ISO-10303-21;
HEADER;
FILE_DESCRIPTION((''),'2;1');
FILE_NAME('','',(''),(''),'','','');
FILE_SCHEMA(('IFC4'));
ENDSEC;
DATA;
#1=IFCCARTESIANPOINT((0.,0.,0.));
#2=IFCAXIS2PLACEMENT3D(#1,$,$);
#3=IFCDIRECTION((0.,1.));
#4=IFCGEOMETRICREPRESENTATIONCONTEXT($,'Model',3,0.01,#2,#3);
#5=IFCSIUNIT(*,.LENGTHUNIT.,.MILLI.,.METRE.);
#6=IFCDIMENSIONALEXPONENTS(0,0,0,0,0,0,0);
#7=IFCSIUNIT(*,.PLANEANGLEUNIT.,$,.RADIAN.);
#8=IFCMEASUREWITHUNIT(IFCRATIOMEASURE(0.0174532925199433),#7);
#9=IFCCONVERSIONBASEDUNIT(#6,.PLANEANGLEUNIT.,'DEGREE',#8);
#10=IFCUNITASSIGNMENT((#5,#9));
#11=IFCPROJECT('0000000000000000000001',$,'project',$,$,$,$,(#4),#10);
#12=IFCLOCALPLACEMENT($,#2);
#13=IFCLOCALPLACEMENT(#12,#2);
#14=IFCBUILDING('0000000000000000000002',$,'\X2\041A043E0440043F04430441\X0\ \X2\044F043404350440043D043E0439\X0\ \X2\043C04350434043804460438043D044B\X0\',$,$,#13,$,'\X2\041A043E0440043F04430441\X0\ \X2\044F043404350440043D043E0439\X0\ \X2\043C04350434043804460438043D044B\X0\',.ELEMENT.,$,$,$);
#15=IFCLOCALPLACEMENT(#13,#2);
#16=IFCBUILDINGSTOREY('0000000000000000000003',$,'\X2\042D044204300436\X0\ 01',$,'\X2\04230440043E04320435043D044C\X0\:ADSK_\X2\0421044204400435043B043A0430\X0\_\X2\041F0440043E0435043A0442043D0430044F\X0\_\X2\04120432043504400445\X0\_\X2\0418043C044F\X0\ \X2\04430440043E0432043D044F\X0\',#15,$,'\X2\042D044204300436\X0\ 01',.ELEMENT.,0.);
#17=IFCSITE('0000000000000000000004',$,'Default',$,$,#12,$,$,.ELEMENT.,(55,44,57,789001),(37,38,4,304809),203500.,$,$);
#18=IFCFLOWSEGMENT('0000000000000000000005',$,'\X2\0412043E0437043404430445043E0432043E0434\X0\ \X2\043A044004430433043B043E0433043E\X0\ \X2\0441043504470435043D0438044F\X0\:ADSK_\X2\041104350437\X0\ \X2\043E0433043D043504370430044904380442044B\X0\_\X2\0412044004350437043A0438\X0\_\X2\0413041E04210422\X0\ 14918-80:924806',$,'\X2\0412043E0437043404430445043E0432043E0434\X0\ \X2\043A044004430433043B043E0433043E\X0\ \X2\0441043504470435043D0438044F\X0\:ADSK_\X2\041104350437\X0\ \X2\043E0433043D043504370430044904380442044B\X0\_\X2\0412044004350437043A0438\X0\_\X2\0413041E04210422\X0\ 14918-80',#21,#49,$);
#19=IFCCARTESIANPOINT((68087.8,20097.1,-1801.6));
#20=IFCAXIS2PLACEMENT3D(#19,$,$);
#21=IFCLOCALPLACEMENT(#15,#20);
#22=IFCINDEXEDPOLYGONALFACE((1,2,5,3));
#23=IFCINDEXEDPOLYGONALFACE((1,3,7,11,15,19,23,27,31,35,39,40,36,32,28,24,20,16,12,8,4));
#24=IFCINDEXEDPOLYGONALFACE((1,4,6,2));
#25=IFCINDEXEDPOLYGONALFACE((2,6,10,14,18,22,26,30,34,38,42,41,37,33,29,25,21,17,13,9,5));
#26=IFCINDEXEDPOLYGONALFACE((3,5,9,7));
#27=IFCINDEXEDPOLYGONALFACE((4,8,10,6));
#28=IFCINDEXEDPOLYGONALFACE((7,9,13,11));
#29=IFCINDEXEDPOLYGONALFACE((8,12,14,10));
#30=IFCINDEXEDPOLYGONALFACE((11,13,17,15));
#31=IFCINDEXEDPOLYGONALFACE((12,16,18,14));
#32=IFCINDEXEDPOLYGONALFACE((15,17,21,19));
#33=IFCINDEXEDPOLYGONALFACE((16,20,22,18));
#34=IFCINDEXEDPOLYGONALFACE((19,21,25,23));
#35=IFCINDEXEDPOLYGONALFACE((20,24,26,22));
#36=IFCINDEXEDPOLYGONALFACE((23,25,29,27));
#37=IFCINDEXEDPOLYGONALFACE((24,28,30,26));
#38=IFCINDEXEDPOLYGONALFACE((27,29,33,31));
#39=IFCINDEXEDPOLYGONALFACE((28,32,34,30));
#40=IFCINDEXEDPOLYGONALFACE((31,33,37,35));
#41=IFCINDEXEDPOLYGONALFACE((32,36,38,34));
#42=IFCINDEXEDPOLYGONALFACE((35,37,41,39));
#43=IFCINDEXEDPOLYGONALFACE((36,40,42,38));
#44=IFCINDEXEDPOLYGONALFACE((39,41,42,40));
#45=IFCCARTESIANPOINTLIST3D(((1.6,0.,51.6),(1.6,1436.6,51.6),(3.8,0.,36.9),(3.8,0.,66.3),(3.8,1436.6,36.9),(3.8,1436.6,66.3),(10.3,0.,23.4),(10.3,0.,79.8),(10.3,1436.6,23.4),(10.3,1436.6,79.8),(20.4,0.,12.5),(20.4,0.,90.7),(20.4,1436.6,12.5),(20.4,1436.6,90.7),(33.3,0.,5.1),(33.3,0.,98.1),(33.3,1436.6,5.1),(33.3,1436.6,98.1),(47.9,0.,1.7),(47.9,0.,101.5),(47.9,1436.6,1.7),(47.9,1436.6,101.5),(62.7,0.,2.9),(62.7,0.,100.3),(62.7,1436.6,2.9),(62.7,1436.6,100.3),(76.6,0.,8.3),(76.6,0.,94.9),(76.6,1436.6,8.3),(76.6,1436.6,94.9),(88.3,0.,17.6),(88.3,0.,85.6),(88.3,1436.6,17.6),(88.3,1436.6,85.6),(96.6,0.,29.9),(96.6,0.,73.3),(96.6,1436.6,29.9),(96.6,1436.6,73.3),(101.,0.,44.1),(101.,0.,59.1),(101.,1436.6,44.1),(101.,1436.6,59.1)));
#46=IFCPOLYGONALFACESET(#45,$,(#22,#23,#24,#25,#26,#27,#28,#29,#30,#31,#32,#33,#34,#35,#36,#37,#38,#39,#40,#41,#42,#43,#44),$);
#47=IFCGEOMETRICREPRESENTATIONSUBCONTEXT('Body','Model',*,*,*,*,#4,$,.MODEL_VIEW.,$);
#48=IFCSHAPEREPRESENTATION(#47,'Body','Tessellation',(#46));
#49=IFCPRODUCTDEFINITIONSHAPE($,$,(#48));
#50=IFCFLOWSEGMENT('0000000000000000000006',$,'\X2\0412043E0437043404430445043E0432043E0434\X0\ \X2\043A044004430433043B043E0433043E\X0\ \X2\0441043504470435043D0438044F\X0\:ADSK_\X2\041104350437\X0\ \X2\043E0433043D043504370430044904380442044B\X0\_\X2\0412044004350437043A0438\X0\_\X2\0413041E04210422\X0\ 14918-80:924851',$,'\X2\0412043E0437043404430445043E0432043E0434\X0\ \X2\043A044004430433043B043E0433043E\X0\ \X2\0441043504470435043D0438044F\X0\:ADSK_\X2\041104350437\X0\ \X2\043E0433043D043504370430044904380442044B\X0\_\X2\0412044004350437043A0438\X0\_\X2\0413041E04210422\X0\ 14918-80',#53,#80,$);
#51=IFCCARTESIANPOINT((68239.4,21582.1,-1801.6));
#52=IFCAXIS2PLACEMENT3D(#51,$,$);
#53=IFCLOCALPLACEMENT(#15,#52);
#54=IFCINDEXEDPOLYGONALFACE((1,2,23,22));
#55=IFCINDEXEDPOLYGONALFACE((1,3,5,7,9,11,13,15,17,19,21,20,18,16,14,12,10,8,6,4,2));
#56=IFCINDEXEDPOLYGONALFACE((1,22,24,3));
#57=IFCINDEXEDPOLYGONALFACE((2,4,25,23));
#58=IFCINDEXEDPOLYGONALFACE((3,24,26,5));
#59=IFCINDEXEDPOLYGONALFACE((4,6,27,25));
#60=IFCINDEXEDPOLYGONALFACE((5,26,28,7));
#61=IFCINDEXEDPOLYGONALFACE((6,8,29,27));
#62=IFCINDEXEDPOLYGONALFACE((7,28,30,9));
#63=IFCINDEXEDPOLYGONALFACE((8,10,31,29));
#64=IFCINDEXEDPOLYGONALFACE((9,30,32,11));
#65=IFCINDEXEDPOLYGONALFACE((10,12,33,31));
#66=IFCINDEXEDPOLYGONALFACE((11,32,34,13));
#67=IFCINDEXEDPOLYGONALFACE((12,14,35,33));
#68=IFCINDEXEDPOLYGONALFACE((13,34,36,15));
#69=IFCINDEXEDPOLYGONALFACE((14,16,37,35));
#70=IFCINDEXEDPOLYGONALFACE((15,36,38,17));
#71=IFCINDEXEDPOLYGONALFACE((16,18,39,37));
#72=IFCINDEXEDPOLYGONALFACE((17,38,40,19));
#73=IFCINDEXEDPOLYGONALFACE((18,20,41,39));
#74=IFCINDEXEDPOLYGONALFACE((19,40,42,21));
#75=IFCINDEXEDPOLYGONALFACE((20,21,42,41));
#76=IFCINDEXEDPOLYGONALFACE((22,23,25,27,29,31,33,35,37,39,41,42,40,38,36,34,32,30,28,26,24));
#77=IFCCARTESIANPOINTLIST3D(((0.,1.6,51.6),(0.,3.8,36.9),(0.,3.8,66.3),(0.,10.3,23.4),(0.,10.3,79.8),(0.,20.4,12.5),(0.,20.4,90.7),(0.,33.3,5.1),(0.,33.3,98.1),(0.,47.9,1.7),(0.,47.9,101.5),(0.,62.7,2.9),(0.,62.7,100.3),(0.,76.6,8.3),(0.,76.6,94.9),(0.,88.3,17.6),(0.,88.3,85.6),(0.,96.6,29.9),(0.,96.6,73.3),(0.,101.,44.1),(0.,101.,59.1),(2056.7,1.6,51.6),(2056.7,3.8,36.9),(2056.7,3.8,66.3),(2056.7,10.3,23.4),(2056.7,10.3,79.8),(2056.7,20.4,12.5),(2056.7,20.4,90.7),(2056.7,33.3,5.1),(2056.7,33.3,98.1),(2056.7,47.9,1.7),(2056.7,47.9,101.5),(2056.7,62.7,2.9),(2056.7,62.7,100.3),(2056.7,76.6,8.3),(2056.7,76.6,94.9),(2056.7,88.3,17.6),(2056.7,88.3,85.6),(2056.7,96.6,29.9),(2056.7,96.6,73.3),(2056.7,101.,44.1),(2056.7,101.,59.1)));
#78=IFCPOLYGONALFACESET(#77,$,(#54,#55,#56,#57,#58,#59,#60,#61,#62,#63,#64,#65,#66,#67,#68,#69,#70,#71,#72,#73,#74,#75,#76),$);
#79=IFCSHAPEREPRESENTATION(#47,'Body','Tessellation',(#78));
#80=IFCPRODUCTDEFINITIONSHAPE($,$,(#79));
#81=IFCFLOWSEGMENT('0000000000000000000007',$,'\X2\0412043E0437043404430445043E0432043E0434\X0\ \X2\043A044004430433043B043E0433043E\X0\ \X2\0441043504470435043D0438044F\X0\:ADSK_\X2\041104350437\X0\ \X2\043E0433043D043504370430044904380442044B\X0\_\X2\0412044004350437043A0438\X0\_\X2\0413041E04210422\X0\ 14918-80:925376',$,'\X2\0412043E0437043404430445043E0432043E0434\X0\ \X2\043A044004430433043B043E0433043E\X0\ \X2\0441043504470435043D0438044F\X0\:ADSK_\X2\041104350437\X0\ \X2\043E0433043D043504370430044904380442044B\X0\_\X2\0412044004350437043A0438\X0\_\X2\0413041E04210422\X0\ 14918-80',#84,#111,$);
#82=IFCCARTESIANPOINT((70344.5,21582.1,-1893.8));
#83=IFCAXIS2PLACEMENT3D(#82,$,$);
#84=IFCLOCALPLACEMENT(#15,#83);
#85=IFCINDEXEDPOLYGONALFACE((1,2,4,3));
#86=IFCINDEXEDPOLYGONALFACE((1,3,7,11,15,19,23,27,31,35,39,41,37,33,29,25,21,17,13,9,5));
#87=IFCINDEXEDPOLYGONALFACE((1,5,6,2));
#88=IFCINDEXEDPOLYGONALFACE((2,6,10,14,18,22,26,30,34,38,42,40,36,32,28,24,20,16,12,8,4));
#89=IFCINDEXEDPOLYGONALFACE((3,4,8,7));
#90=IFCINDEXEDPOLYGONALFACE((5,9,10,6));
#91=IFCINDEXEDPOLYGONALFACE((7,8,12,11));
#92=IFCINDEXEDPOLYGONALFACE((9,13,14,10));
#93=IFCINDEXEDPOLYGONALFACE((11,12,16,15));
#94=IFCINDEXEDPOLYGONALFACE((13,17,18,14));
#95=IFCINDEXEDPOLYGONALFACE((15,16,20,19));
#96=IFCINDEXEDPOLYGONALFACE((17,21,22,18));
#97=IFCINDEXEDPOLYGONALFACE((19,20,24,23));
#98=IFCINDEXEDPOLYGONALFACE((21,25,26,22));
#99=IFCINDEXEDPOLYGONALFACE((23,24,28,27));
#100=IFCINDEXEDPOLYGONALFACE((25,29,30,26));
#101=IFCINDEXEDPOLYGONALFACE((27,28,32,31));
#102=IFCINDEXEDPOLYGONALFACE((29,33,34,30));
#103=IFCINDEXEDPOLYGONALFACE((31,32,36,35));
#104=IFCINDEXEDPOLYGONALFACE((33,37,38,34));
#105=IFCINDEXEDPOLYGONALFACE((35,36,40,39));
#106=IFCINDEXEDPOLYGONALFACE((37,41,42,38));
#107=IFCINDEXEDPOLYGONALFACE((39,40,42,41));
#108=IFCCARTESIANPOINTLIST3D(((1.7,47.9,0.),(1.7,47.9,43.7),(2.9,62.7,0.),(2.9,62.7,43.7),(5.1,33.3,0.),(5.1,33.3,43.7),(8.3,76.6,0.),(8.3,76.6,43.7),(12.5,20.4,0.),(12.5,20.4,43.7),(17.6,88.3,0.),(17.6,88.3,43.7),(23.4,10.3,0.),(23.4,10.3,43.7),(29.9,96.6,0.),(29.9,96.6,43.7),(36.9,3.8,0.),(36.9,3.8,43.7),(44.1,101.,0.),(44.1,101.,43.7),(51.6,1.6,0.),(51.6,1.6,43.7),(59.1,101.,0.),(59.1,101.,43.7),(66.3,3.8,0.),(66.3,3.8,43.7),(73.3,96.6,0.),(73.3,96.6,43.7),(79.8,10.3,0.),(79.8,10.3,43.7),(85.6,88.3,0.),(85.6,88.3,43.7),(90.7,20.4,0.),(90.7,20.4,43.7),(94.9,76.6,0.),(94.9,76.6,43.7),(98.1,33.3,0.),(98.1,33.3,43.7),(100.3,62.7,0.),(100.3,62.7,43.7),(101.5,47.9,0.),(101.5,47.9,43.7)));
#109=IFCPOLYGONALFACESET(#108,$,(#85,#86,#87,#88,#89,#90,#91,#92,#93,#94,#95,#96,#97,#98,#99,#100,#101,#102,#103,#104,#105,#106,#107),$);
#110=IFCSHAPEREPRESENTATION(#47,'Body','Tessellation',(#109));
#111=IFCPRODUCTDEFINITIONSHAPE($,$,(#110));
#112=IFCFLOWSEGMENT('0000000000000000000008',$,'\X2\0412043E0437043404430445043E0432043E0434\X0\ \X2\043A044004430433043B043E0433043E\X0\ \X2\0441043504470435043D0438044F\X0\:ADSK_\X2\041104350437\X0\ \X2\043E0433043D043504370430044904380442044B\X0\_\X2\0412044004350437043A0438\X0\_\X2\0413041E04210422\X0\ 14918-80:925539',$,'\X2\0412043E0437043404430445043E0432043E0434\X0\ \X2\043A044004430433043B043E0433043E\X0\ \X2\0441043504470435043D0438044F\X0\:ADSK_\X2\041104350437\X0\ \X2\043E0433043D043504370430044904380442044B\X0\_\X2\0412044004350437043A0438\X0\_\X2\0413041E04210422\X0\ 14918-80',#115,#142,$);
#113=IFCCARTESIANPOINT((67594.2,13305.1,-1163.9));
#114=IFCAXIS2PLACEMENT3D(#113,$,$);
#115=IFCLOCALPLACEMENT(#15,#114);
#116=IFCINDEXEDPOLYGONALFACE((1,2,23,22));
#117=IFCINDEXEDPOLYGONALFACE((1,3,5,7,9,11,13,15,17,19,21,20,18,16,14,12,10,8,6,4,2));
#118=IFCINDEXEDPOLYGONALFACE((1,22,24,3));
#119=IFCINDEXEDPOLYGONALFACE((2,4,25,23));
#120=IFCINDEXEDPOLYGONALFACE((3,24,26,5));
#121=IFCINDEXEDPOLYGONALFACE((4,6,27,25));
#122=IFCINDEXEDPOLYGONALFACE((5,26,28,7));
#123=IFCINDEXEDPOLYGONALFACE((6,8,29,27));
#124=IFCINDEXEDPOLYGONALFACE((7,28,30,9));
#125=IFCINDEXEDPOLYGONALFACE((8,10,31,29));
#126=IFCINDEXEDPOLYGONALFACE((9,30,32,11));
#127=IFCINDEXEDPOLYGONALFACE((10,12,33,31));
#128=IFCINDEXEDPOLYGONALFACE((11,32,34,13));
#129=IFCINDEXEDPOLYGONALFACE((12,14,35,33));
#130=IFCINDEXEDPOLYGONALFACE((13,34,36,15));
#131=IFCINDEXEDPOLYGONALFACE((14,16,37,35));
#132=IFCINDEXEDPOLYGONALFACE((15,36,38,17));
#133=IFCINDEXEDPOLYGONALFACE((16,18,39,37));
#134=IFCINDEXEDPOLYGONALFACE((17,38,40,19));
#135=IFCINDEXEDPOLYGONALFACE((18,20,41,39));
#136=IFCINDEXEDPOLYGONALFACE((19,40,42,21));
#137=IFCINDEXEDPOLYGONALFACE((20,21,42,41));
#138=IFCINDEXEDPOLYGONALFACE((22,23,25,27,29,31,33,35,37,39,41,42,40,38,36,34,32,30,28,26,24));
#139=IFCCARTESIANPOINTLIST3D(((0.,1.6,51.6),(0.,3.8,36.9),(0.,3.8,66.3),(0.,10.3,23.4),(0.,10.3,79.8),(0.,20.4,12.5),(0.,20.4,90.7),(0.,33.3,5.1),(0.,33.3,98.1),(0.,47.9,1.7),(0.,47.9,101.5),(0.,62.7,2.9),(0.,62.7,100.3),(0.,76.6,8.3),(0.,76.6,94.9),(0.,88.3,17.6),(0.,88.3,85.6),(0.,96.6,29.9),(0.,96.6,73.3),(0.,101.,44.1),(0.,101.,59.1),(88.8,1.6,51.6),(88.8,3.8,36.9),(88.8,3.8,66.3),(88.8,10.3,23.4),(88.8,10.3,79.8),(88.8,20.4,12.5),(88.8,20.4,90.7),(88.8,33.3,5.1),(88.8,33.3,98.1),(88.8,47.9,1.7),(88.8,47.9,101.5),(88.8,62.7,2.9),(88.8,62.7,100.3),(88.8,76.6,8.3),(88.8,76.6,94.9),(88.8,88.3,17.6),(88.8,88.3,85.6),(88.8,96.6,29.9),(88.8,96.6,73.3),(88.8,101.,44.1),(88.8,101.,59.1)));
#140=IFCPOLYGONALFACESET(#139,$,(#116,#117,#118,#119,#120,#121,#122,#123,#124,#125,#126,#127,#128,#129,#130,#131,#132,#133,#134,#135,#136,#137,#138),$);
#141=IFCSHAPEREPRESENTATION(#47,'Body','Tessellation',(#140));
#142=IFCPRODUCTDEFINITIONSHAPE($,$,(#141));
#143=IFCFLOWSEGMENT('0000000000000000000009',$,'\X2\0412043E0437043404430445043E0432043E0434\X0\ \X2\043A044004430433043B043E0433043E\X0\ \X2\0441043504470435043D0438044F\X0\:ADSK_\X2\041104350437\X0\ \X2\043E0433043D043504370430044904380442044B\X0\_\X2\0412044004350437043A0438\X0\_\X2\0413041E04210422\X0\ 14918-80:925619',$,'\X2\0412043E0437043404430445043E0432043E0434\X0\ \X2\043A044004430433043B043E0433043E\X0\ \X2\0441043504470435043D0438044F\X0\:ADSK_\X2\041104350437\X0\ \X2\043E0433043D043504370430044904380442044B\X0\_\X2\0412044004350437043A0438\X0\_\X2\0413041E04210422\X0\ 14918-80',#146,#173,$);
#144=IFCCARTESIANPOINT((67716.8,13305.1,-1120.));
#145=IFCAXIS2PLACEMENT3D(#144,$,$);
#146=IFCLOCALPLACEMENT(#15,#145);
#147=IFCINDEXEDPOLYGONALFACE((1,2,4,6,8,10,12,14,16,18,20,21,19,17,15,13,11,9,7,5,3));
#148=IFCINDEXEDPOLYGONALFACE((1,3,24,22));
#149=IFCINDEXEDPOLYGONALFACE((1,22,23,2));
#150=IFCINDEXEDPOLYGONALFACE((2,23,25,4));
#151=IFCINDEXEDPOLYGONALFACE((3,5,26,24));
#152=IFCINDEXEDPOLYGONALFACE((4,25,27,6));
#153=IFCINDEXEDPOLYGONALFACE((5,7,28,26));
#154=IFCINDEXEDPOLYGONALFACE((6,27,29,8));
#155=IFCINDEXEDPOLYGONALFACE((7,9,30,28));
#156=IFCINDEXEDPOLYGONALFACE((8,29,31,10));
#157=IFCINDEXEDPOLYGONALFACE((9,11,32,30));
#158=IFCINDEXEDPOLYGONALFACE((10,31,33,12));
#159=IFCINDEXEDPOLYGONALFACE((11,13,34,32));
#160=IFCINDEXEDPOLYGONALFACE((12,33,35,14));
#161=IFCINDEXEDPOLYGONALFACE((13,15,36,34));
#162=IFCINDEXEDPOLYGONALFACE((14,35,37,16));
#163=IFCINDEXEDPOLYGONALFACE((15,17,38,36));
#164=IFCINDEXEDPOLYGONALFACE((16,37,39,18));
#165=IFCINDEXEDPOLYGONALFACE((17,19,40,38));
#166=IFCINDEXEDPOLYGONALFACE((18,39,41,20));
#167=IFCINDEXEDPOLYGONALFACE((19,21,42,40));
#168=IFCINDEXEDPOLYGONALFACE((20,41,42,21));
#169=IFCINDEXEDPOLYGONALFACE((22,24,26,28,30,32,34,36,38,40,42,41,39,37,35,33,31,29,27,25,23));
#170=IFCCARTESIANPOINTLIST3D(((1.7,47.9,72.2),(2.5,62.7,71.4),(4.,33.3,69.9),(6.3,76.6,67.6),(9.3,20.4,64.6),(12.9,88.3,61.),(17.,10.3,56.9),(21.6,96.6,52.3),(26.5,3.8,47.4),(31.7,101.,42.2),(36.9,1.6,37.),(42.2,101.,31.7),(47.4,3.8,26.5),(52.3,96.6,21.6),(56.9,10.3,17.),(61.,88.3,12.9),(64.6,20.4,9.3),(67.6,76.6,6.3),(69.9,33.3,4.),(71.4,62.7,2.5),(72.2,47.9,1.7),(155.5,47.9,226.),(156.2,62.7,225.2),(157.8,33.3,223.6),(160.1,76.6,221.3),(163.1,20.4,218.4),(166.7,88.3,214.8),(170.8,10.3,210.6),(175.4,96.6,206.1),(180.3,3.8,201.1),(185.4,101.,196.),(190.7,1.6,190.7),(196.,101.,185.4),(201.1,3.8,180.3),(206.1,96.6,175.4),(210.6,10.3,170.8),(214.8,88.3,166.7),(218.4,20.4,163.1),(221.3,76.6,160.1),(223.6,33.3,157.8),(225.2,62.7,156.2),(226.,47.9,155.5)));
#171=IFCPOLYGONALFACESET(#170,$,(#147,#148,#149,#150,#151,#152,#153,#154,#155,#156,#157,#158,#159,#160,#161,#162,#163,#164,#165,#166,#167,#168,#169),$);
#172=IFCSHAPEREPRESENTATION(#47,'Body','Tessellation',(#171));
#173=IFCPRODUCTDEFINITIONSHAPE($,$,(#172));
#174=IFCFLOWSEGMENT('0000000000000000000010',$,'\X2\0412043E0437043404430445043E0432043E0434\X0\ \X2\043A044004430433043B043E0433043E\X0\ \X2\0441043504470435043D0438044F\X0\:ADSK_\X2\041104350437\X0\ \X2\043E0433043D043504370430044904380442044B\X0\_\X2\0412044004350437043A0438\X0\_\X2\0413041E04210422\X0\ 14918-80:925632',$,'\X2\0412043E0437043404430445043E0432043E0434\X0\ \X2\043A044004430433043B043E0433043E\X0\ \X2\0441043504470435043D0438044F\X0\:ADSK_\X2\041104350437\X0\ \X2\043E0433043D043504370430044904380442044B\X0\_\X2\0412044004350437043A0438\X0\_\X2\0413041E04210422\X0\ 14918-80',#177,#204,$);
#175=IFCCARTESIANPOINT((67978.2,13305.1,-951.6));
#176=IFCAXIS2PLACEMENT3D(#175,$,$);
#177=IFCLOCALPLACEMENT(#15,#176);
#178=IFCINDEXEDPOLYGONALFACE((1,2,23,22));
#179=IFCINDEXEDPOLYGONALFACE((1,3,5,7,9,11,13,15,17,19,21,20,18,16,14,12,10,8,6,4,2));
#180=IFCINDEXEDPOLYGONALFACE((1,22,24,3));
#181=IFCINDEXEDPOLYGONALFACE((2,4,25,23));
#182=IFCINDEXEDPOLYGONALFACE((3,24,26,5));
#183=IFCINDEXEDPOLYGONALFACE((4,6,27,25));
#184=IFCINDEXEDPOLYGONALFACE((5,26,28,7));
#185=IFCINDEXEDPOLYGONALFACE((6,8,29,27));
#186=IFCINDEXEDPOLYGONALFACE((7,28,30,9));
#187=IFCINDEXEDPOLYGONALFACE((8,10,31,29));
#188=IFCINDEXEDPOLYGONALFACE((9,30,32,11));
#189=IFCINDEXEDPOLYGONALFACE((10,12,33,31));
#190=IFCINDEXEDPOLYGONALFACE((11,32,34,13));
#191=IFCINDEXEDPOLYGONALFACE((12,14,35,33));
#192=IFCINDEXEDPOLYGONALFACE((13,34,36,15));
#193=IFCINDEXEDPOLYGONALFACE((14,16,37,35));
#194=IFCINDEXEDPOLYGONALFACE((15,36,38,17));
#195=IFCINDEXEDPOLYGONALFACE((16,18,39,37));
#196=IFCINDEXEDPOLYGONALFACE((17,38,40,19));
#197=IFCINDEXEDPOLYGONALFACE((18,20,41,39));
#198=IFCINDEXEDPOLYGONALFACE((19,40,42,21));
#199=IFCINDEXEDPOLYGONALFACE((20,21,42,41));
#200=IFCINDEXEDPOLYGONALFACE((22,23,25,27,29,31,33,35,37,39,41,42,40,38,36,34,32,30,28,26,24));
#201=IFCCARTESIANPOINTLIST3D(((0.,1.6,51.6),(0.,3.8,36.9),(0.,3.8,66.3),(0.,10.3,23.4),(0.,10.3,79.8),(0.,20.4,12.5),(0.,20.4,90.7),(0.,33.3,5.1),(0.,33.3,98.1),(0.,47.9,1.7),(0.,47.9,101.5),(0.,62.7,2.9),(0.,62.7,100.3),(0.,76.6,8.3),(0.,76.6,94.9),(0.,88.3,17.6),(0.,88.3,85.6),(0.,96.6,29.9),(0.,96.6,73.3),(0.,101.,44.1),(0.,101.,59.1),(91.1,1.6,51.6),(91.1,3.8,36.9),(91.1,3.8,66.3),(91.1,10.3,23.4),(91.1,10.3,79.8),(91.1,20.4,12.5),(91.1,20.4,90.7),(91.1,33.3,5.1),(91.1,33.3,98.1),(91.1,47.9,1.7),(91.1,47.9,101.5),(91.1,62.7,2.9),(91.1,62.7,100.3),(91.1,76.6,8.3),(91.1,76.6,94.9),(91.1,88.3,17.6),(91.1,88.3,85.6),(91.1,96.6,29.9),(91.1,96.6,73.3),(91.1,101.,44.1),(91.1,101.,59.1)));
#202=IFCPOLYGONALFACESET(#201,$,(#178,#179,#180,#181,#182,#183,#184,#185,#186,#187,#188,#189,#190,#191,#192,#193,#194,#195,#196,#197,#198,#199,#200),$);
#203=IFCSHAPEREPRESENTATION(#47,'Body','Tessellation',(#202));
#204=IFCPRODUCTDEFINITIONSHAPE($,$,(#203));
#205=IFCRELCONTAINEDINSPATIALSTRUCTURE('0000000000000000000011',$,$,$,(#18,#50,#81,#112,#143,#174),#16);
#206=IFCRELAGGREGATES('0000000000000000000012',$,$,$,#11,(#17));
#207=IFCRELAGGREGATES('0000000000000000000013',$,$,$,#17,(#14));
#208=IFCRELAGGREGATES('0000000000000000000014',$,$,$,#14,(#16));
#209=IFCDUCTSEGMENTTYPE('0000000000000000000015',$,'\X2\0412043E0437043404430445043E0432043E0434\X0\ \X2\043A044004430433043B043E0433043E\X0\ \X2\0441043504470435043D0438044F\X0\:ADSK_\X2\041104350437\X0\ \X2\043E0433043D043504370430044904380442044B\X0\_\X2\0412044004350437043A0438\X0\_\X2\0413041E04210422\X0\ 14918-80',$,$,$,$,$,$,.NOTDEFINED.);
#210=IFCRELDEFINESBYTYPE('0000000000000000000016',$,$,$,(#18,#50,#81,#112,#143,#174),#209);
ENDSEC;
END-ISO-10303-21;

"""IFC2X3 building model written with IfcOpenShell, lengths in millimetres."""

from ifc_helpers import new_model, entity, si_unit, converted_unit, direction, frame, origin, origin_2d_with_axis, place, context, subcontext, project, spatial, circle, extrude, type_object, element, save


model = new_model("IFC2X3")

# Units and contexts
model_context = context("Model", 3, precision=0.01, world=origin(), true_north=direction((0.0, 1.0)))
body_context = subcontext(model_context, "Body", "Model", "MODEL_VIEW")
ifc_project = project(units=[si_unit("LENGTHUNIT", "METRE", prefix="MILLI"), converted_unit("PLANEANGLEUNIT", "DEGREE", entity("IfcRatioMeasure", 0.0174532925199433), si_unit("PLANEANGLEUNIT", "RADIAN"), dimensions=[0, 0, 0, 0, 0, 0, 0])], contexts=[model_context])

# Site, building, storey
site_placement = place(None, origin())
site = spatial("IfcSite", under=ifc_project, at=site_placement, Name="Default", CompositionType="ELEMENT", RefLatitude=(55, 44, 57, 789001), RefLongitude=(37, 38, 4, 304809), RefElevation=203500.0)
building_placement = place(site_placement, origin())
building = spatial("IfcBuilding", under=site, at=building_placement, Name="Корпус ядерной медицины", LongName="Корпус ядерной медицины", CompositionType="ELEMENT")
storey_placement = place(building_placement, origin())
storey = spatial("IfcBuildingStorey", under=building, at=storey_placement, Name="Этаж 01", ObjectType="Уровень:ADSK_Стрелка_Проектная_Вверх_Имя уровня", LongName="Этаж 01", CompositionType="ELEMENT", Elevation=0.0)

# Flow segments
duct_segment_type = type_object("IfcDuctSegmentType", Name="Воздуховод круглого сечения:ADSK_Без огнезащиты_Врезки_ГОСТ 14918-80", PredefinedType="NOTDEFINED")
flow_segment_1_placement = place(storey_placement, frame((68087.8, 20097.1, -1801.6)))
element("IfcFlowSegment", 1, at=flow_segment_1_placement, inside=storey, type_object=duct_segment_type, Name="Воздуховод круглого сечения:ADSK_Без огнезащиты_Врезки_ГОСТ 14918-80:924806", ObjectType="Воздуховод круглого сечения:ADSK_Без огнезащиты_Врезки_ГОСТ 14918-80", context=body_context, shape_type="SweptSolid", body=[
    extrude(circle(Radius=50.0, at=origin_2d_with_axis()), frame((51.6, 0.0, 51.6), z_axis=(0.0, 1.0, 0.0), x_axis=(-1.0, 0.0, 0.0)), (0.0, 0.0, 1.0), 1436.6),
])
flow_segment_2_placement = place(storey_placement, frame((68239.4, 21582.1, -1801.6)))
element("IfcFlowSegment", 2, at=flow_segment_2_placement, inside=storey, type_object=duct_segment_type, Name="Воздуховод круглого сечения:ADSK_Без огнезащиты_Врезки_ГОСТ 14918-80:924851", ObjectType="Воздуховод круглого сечения:ADSK_Без огнезащиты_Врезки_ГОСТ 14918-80", context=body_context, shape_type="SweptSolid", body=[
    extrude(circle(Radius=50.0, at=origin_2d_with_axis()), frame((0.0, 51.6, 51.6), z_axis=(1.0, 0.0, 0.0), x_axis=(0.0, -1.0, 0.0)), (0.0, 0.0, 1.0), 2056.7),
])
flow_segment_3_placement = place(storey_placement, frame((70344.5, 21582.1, -1893.8)))
element("IfcFlowSegment", 3, at=flow_segment_3_placement, inside=storey, type_object=duct_segment_type, Name="Воздуховод круглого сечения:ADSK_Без огнезащиты_Врезки_ГОСТ 14918-80:925376", ObjectType="Воздуховод круглого сечения:ADSK_Без огнезащиты_Врезки_ГОСТ 14918-80", context=body_context, shape_type="SweptSolid", body=[
    extrude(circle(Radius=50.0, at=origin_2d_with_axis()), frame((51.6, 51.6, 0.0), z_axis=(0.0, 0.0, 1.0), x_axis=(0.0, -1.0, 0.0)), (0.0, 0.0, 1.0), 43.7),
])
flow_segment_4_placement = place(storey_placement, frame((67594.2, 13305.1, -1163.9)))
element("IfcFlowSegment", 4, at=flow_segment_4_placement, inside=storey, type_object=duct_segment_type, Name="Воздуховод круглого сечения:ADSK_Без огнезащиты_Врезки_ГОСТ 14918-80:925539", ObjectType="Воздуховод круглого сечения:ADSK_Без огнезащиты_Врезки_ГОСТ 14918-80", context=body_context, shape_type="SweptSolid", body=[
    extrude(circle(Radius=50.0, at=origin_2d_with_axis()), frame((0.0, 51.6, 51.6), z_axis=(1.0, 0.0, 0.0), x_axis=(0.0, -1.0, 0.0)), (0.0, 0.0, 1.0), 88.8),
])
flow_segment_5_placement = place(storey_placement, frame((67716.8, 13305.1, -1120.0)))
element("IfcFlowSegment", 5, at=flow_segment_5_placement, inside=storey, type_object=duct_segment_type, Name="Воздуховод круглого сечения:ADSK_Без огнезащиты_Врезки_ГОСТ 14918-80:925619", ObjectType="Воздуховод круглого сечения:ADSK_Без огнезащиты_Врезки_ГОСТ 14918-80", context=body_context, shape_type="SweptSolid", body=[
    extrude(circle(Radius=50.0, at=origin_2d_with_axis()), frame((37.0, 51.6, 37.0), z_axis=(0.707107, 0.0, 0.707107), x_axis=(0.0, -1.0, 0.0)), (0.0, 0.0, 1.0), 217.5),
])
flow_segment_6_placement = place(storey_placement, frame((67978.2, 13305.1, -951.6)))
element("IfcFlowSegment", 6, at=flow_segment_6_placement, inside=storey, type_object=duct_segment_type, Name="Воздуховод круглого сечения:ADSK_Без огнезащиты_Врезки_ГОСТ 14918-80:925632", ObjectType="Воздуховод круглого сечения:ADSK_Без огнезащиты_Врезки_ГОСТ 14918-80", context=body_context, shape_type="SweptSolid", body=[
    extrude(circle(Radius=50.0, at=origin_2d_with_axis()), frame((0.0, 51.6, 51.6), z_axis=(1.0, 0.0, 0.0), x_axis=(0.0, -1.0, 0.0)), (0.0, 0.0, 1.0), 91.1),
])

save(model, "model.ifc")
